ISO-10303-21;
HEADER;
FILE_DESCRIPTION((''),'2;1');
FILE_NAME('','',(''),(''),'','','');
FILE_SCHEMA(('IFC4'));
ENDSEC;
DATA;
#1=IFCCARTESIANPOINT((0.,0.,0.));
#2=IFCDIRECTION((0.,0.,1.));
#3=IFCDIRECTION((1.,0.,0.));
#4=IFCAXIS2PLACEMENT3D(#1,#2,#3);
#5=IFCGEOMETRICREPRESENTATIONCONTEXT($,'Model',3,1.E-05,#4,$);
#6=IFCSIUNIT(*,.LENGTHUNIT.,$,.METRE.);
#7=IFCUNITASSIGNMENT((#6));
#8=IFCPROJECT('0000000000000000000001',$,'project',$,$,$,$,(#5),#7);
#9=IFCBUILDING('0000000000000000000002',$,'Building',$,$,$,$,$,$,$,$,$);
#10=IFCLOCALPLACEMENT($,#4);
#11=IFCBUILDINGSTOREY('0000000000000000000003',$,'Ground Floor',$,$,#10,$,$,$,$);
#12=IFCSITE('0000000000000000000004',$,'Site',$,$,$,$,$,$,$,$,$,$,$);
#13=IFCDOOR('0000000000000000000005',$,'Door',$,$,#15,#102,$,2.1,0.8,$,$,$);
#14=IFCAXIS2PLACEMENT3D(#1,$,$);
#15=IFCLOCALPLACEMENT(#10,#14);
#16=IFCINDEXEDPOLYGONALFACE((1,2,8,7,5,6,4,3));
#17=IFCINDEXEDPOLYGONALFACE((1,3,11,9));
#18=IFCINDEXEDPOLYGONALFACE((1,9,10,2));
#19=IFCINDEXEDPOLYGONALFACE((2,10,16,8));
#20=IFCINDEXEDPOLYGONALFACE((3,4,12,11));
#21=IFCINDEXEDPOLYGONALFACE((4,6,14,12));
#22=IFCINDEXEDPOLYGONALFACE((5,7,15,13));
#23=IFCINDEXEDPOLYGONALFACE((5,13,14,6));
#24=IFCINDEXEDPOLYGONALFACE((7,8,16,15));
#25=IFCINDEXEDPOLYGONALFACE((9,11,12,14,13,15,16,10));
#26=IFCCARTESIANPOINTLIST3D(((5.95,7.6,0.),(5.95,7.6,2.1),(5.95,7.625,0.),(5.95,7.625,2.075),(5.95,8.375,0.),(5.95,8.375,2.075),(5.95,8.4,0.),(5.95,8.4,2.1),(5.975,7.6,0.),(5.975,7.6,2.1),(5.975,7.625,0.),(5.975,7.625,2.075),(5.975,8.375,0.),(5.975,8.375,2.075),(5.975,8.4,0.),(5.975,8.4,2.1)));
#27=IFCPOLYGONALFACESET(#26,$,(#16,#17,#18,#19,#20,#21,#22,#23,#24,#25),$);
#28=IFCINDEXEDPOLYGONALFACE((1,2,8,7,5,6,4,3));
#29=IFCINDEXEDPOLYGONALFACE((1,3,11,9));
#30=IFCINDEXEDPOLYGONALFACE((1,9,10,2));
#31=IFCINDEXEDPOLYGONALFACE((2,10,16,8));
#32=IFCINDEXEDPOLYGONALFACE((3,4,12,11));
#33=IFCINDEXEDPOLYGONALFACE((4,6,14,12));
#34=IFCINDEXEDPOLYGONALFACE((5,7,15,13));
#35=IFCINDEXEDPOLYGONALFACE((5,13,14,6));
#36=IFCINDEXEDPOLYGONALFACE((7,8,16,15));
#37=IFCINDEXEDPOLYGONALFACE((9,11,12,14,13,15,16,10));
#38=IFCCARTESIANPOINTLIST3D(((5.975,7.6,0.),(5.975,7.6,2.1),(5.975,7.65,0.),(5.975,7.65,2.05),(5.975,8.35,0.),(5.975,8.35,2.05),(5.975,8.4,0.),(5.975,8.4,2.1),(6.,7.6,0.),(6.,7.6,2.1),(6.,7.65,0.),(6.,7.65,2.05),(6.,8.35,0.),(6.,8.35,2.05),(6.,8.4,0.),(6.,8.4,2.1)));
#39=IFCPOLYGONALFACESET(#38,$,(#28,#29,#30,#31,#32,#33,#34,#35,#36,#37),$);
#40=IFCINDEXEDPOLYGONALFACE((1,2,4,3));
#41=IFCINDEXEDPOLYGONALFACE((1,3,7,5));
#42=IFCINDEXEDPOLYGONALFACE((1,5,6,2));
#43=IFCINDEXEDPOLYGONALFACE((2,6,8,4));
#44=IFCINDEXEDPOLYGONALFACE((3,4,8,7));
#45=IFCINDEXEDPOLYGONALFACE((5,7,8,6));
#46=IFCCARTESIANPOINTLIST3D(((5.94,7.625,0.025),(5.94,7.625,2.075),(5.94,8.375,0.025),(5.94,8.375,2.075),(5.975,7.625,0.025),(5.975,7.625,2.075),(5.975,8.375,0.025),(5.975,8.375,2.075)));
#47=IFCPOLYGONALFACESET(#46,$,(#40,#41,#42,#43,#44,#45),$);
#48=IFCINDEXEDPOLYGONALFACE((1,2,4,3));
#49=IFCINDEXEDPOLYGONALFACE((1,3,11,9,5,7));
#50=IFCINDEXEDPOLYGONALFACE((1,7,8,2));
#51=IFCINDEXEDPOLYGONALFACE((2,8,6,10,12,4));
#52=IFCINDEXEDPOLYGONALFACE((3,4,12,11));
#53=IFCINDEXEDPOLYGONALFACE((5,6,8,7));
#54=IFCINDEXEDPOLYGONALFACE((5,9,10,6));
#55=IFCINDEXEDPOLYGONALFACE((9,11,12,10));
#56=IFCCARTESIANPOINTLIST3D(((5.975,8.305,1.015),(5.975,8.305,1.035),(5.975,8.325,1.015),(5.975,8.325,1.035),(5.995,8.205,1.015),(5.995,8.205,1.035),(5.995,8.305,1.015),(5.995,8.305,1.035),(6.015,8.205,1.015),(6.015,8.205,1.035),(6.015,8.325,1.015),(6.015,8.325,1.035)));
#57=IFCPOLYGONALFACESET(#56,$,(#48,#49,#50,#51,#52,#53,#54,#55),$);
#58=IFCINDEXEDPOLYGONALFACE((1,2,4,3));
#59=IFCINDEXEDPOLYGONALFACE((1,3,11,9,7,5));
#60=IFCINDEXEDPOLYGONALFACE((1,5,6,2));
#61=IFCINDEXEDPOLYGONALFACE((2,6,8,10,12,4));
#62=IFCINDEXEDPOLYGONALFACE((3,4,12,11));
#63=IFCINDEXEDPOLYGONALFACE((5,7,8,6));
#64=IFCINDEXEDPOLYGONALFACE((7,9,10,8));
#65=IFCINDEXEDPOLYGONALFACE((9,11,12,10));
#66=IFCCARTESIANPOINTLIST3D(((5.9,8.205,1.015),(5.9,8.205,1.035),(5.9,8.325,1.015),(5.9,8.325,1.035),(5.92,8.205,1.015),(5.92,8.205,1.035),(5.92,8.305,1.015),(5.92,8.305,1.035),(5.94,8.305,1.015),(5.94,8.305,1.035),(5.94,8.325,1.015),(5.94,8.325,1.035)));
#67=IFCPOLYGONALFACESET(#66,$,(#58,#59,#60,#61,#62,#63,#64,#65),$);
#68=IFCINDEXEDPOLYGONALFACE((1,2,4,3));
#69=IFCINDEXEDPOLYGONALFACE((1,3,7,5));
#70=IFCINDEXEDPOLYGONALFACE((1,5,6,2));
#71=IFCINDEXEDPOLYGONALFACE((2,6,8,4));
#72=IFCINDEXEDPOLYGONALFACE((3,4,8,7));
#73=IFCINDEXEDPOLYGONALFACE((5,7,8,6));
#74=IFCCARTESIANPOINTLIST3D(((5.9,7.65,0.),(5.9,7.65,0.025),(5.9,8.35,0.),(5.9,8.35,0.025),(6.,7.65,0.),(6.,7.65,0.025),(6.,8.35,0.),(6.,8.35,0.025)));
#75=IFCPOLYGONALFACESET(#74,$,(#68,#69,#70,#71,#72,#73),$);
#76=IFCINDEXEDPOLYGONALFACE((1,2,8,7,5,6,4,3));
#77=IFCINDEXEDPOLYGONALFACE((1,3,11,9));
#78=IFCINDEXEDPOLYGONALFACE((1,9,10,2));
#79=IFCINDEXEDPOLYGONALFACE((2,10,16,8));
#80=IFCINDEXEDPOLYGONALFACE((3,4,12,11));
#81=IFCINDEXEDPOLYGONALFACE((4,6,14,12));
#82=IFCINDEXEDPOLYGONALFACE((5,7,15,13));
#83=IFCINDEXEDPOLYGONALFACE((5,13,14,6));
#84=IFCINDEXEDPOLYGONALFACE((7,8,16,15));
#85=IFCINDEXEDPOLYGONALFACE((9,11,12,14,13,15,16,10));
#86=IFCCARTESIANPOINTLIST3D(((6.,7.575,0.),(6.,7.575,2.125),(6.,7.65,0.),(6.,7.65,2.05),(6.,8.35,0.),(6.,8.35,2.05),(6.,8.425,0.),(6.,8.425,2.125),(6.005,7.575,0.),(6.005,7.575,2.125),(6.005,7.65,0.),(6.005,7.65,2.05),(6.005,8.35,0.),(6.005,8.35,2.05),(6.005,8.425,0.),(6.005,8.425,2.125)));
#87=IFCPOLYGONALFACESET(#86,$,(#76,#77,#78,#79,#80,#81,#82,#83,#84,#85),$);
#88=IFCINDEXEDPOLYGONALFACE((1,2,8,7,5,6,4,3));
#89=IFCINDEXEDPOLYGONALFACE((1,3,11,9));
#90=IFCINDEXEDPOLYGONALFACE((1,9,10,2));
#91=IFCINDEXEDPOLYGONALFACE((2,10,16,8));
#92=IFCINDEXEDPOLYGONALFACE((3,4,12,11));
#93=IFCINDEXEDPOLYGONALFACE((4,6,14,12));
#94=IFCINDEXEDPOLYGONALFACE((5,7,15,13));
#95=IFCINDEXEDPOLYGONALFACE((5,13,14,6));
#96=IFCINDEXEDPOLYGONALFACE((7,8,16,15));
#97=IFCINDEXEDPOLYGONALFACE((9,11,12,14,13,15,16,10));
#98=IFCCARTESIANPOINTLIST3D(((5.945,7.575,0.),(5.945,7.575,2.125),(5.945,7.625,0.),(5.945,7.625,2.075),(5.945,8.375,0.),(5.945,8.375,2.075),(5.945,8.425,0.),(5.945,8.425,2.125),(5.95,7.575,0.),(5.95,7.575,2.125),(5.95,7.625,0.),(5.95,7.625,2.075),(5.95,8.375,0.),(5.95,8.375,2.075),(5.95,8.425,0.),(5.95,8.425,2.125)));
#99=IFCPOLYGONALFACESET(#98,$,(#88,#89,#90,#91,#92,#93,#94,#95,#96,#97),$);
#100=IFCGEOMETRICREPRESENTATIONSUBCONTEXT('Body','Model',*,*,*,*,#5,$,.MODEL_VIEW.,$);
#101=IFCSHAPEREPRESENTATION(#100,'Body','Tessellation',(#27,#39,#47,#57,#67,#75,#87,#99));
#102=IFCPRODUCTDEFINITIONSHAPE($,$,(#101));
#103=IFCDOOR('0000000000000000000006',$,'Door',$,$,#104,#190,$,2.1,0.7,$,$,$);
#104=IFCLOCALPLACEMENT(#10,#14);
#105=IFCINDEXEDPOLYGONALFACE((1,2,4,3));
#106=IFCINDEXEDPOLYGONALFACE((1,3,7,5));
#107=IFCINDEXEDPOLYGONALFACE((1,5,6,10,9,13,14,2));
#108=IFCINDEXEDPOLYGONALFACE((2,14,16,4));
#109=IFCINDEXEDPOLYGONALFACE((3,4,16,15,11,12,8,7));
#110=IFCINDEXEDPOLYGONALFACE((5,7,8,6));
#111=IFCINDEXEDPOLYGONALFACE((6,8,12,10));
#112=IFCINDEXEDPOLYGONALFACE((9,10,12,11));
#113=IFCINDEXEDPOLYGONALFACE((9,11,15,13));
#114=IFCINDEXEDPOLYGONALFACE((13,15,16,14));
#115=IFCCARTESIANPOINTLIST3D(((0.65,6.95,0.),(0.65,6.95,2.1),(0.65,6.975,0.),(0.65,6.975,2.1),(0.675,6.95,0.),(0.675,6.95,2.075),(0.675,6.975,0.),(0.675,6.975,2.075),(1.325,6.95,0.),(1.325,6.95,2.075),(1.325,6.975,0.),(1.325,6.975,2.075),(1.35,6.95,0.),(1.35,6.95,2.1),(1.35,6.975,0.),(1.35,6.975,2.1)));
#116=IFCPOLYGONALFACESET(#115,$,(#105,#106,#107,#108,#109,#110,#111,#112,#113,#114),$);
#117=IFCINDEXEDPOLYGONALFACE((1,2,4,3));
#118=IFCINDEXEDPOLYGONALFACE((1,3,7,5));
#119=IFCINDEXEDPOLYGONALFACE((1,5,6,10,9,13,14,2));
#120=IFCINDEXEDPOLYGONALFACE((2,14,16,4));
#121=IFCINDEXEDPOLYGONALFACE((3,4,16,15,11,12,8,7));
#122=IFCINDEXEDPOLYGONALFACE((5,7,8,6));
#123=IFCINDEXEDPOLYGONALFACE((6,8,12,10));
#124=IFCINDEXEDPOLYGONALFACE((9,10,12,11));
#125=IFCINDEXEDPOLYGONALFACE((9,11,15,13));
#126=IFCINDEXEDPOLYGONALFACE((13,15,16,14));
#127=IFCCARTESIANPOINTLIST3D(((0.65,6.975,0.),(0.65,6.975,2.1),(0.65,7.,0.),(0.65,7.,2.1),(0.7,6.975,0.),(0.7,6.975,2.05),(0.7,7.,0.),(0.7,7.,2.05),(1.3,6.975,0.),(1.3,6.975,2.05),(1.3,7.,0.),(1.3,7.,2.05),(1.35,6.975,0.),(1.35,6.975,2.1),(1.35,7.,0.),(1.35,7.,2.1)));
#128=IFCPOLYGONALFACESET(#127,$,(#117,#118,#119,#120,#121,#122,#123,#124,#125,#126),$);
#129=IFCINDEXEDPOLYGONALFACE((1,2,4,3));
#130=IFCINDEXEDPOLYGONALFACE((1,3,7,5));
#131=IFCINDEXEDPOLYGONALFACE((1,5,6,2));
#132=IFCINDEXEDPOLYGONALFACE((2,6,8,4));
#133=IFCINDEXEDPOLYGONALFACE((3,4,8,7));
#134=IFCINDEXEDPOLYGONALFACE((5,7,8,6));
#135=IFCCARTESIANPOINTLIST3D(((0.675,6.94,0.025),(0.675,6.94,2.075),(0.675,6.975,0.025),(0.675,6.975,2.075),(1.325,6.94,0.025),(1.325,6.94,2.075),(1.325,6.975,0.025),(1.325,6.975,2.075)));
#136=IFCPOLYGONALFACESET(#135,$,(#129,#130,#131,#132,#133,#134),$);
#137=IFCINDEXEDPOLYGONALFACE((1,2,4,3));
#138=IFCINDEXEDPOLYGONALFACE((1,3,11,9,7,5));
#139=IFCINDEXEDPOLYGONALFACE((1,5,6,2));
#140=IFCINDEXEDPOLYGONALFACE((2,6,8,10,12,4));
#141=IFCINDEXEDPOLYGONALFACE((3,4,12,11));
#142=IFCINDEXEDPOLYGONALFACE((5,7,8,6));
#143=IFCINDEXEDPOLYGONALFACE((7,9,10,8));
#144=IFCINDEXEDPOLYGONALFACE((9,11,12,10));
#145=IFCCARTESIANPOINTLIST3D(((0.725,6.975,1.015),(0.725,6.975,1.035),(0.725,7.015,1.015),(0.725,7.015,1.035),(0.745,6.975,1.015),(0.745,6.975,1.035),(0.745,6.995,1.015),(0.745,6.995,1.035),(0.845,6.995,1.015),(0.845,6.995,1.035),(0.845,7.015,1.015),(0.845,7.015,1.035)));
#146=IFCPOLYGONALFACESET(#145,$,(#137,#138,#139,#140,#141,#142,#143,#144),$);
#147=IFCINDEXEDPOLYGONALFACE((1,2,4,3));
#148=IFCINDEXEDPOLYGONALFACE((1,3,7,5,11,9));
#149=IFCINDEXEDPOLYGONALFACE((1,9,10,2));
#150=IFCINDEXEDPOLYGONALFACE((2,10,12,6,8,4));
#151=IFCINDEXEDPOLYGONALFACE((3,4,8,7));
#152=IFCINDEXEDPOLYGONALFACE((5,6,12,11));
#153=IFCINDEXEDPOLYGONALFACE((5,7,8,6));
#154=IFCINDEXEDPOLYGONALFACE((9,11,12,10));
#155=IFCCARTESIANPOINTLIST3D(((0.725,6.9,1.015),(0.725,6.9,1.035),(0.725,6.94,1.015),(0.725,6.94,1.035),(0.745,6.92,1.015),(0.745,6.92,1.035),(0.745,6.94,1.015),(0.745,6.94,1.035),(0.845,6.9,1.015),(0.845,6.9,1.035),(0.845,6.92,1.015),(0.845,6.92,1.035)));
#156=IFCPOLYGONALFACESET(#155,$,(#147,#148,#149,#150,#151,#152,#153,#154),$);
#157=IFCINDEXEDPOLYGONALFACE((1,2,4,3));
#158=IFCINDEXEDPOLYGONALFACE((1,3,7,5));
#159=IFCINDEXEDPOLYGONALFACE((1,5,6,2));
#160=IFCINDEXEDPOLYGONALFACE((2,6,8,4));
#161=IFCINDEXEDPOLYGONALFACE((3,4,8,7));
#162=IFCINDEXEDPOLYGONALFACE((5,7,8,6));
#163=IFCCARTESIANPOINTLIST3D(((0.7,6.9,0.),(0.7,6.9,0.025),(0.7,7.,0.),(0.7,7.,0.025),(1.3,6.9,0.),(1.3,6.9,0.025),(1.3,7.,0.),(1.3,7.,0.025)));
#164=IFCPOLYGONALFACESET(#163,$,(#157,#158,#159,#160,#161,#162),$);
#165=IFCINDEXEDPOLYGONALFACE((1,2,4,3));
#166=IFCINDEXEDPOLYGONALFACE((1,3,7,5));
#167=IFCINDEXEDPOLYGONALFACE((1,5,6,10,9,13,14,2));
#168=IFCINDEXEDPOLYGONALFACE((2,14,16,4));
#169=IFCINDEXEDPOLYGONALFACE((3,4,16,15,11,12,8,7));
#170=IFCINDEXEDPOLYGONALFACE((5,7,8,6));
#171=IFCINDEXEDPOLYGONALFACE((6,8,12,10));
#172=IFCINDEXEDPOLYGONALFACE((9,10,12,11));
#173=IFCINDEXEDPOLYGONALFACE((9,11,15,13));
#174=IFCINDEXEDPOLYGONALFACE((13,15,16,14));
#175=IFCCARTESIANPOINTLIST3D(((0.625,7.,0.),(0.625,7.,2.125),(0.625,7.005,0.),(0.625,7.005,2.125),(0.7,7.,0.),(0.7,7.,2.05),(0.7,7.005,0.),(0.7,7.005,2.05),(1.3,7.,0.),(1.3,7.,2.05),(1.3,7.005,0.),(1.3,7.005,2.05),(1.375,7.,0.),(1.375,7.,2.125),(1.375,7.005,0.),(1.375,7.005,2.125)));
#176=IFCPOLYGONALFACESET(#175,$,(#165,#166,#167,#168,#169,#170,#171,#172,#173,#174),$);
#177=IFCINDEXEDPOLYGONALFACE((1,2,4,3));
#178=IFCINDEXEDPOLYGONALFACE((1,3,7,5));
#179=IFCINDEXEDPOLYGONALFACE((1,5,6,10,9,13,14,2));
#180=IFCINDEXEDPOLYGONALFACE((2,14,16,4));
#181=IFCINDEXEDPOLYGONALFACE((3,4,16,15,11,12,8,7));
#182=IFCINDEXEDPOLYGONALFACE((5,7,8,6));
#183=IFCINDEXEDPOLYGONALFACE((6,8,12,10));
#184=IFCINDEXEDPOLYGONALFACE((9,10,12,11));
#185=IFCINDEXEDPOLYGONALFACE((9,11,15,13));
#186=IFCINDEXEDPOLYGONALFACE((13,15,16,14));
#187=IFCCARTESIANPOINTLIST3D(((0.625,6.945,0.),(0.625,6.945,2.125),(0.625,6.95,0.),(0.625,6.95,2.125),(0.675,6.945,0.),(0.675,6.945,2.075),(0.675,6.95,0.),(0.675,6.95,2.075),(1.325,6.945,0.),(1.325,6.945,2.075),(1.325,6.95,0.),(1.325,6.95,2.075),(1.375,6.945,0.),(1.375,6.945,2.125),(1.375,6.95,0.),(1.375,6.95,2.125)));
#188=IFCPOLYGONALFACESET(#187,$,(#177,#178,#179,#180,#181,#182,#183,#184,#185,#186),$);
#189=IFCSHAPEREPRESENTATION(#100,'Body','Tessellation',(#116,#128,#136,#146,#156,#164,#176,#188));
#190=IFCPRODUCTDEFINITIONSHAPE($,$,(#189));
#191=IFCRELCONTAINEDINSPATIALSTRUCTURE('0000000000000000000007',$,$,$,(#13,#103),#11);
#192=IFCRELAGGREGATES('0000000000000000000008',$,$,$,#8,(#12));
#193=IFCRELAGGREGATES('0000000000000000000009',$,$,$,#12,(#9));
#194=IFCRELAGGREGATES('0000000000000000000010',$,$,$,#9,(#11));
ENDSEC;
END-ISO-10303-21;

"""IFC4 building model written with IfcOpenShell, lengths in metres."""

from ifc_helpers import new_model, si_unit, frame, origin_with_axes, place, context, subcontext, project, spatial, line, indexed_curve, outline, extrude, element, save


model = new_model("IFC4")

# Units and contexts
model_context = context("Model", 3, precision=1e-05, world=origin_with_axes())
body_context = subcontext(model_context, "Body", "Model", "MODEL_VIEW")
ifc_project = project(units=[si_unit("LENGTHUNIT", "METRE")], contexts=[model_context])

# Site, building, storey
site = spatial("IfcSite", under=ifc_project, Name="Site")
building = spatial("IfcBuilding", under=site, Name="Building")
storey_placement = place(None, origin_with_axes())
storey = spatial("IfcBuildingStorey", under=building, at=storey_placement, Name="Ground Floor")

# Doors
door_1_placement = place(storey_placement, frame((6.0, 7.6, 0.0), z_axis=(0.0, 0.0, 1.0), x_axis=(0.0, 1.0, 0.0)))
element("IfcDoor", 1, at=door_1_placement, inside=storey, Name="Door", OverallHeight=2.1, OverallWidth=0.8, context=body_context, shape_type="SweptSolid", body=[
    extrude(outline(indexed_curve([(0.0, 0.0), (0.0, 2.1), (0.8, 2.1), (0.8, 0.0), (0.775, 0.0), (0.775, 2.075), (0.025, 2.075), (0.025, 0.0)], segments=[line(1, 2, 3, 4, 5, 6, 7, 8, 1)])), frame((0.0, 0.025, 0.0), z_axis=(0.0, -1.0, 0.0), x_axis=(1.0, 0.0, 0.0)), (0.0, 0.0, -1.0), 0.025),
    extrude(outline(indexed_curve([(0.0, 0.0), (0.0, 2.1), (0.8, 2.1), (0.8, 0.0), (0.75, 0.0), (0.75, 2.05), (0.05, 2.05), (0.05, 0.0)], segments=[line(1, 2, 3, 4, 5, 6, 7, 8, 1)])), frame((0.0, 0.0, 0.0), z_axis=(0.0, -1.0, 0.0), x_axis=(1.0, 0.0, 0.0)), (0.0, 0.0, -1.0), 0.025),
    extrude(outline(indexed_curve([(0.0, 0.0), (0.75, 0.0), (0.75, 0.035), (0.0, 0.035)], segments=[line(1, 2, 3, 4, 1)])), frame((0.025, 0.025, 0.025), z_axis=(0.0, 0.0, 1.0), x_axis=(1.0, 0.0, 0.0)), (0.0, 0.0, 1.0), 2.05),
    extrude(outline(indexed_curve([(0.0, 0.0), (0.0, -0.04), (-0.12, -0.04), (-0.12, -0.02), (-0.02, -0.02), (-0.02, 0.0)], segments=[line(1, 2, 3, 4, 5, 6, 1)])), frame((0.725, 0.025, 1.015), z_axis=(0.0, 0.0, 1.0), x_axis=(1.0, 0.0, 0.0)), (0.0, 0.0, 1.0), 0.02),
    extrude(outline(indexed_curve([(0.0, 0.0), (0.0, 0.04), (-0.12, 0.04), (-0.12, 0.02), (-0.02, 0.02), (-0.02, 0.0)], segments=[line(1, 2, 3, 4, 5, 6, 1)])), frame((0.725, 0.06, 1.015), z_axis=(0.0, 0.0, 1.0), x_axis=(1.0, 0.0, 0.0)), (0.0, 0.0, 1.0), 0.02),
    extrude(outline(indexed_curve([(0.0, 0.0), (0.7, 0.0), (0.7, 0.1), (0.0, 0.1)], segments=[line(1, 2, 3, 4, 1)])), frame((0.05, 0.0, 0.0), z_axis=(0.0, 0.0, 1.0), x_axis=(1.0, 0.0, 0.0)), (0.0, 0.0, 1.0), 0.025),
    extrude(outline(indexed_curve([(0.0, 0.0), (0.0, 2.125), (0.85, 2.125), (0.85, 0.0), (0.775, 0.0), (0.775, 2.05), (0.075, 2.05), (0.075, 0.0)], segments=[line(1, 2, 3, 4, 5, 6, 7, 8, 1)])), frame((-0.025, -0.005, 0.0), z_axis=(0.0, -1.0, 0.0), x_axis=(1.0, 0.0, 0.0)), (0.0, 0.0, -1.0), 0.005),
    extrude(outline(indexed_curve([(0.0, 0.0), (0.0, 2.125), (0.85, 2.125), (0.85, 0.0), (0.8, 0.0), (0.8, 2.075), (0.05, 2.075), (0.05, 0.0)], segments=[line(1, 2, 3, 4, 5, 6, 7, 8, 1)])), frame((-0.025, 0.05, 0.0), z_axis=(0.0, -1.0, 0.0), x_axis=(1.0, 0.0, 0.0)), (0.0, 0.0, -1.0), 0.005),
])
door_2_placement = place(storey_placement, frame((1.35, 7.0, 0.0), z_axis=(0.0, 0.0, 1.0), x_axis=(-1.0, 0.0, 0.0)))
element("IfcDoor", 2, at=door_2_placement, inside=storey, Name="Door", OverallHeight=2.1, OverallWidth=0.7, context=body_context, shape_type="SweptSolid", body=[
    extrude(outline(indexed_curve([(0.0, 0.0), (0.0, 2.1), (0.7, 2.1), (0.7, 0.0), (0.675, 0.0), (0.675, 2.075), (0.025, 2.075), (0.025, 0.0)], segments=[line(1, 2, 3, 4, 5, 6, 7, 8, 1)])), frame((0.0, 0.025, 0.0), z_axis=(0.0, -1.0, 0.0), x_axis=(1.0, 0.0, 0.0)), (0.0, 0.0, -1.0), 0.025),
    extrude(outline(indexed_curve([(0.0, 0.0), (0.0, 2.1), (0.7, 2.1), (0.7, 0.0), (0.65, 0.0), (0.65, 2.05), (0.05, 2.05), (0.05, 0.0)], segments=[line(1, 2, 3, 4, 5, 6, 7, 8, 1)])), frame((0.0, 0.0, 0.0), z_axis=(0.0, -1.0, 0.0), x_axis=(1.0, 0.0, 0.0)), (0.0, 0.0, -1.0), 0.025),
    extrude(outline(indexed_curve([(0.0, 0.0), (0.65, 0.0), (0.65, 0.035), (0.0, 0.035)], segments=[line(1, 2, 3, 4, 1)])), frame((0.025, 0.025, 0.025), z_axis=(0.0, 0.0, 1.0), x_axis=(1.0, 0.0, 0.0)), (0.0, 0.0, 1.0), 2.05),
    extrude(outline(indexed_curve([(0.0, 0.0), (0.0, -0.04), (-0.12, -0.04), (-0.12, -0.02), (-0.02, -0.02), (-0.02, 0.0)], segments=[line(1, 2, 3, 4, 5, 6, 1)])), frame((0.625, 0.025, 1.015), z_axis=(0.0, 0.0, 1.0), x_axis=(1.0, 0.0, 0.0)), (0.0, 0.0, 1.0), 0.02),
    extrude(outline(indexed_curve([(0.0, 0.0), (0.0, 0.04), (-0.12, 0.04), (-0.12, 0.02), (-0.02, 0.02), (-0.02, 0.0)], segments=[line(1, 2, 3, 4, 5, 6, 1)])), frame((0.625, 0.06, 1.015), z_axis=(0.0, 0.0, 1.0), x_axis=(1.0, 0.0, 0.0)), (0.0, 0.0, 1.0), 0.02),
    extrude(outline(indexed_curve([(0.0, 0.0), (0.6, 0.0), (0.6, 0.1), (0.0, 0.1)], segments=[line(1, 2, 3, 4, 1)])), frame((0.05, 0.0, 0.0), z_axis=(0.0, 0.0, 1.0), x_axis=(1.0, 0.0, 0.0)), (0.0, 0.0, 1.0), 0.025),
    extrude(outline(indexed_curve([(0.0, 0.0), (0.0, 2.125), (0.75, 2.125), (0.75, 0.0), (0.675, 0.0), (0.675, 2.05), (0.075, 2.05), (0.075, 0.0)], segments=[line(1, 2, 3, 4, 5, 6, 7, 8, 1)])), frame((-0.025, -0.005, 0.0), z_axis=(0.0, -1.0, 0.0), x_axis=(1.0, 0.0, 0.0)), (0.0, 0.0, -1.0), 0.005),
    extrude(outline(indexed_curve([(0.0, 0.0), (0.0, 2.125), (0.75, 2.125), (0.75, 0.0), (0.7, 0.0), (0.7, 2.075), (0.05, 2.075), (0.05, 0.0)], segments=[line(1, 2, 3, 4, 5, 6, 7, 8, 1)])), frame((-0.025, 0.05, 0.0), z_axis=(0.0, -1.0, 0.0), x_axis=(1.0, 0.0, 0.0)), (0.0, 0.0, -1.0), 0.005),
])

save(model, "model.ifc")
